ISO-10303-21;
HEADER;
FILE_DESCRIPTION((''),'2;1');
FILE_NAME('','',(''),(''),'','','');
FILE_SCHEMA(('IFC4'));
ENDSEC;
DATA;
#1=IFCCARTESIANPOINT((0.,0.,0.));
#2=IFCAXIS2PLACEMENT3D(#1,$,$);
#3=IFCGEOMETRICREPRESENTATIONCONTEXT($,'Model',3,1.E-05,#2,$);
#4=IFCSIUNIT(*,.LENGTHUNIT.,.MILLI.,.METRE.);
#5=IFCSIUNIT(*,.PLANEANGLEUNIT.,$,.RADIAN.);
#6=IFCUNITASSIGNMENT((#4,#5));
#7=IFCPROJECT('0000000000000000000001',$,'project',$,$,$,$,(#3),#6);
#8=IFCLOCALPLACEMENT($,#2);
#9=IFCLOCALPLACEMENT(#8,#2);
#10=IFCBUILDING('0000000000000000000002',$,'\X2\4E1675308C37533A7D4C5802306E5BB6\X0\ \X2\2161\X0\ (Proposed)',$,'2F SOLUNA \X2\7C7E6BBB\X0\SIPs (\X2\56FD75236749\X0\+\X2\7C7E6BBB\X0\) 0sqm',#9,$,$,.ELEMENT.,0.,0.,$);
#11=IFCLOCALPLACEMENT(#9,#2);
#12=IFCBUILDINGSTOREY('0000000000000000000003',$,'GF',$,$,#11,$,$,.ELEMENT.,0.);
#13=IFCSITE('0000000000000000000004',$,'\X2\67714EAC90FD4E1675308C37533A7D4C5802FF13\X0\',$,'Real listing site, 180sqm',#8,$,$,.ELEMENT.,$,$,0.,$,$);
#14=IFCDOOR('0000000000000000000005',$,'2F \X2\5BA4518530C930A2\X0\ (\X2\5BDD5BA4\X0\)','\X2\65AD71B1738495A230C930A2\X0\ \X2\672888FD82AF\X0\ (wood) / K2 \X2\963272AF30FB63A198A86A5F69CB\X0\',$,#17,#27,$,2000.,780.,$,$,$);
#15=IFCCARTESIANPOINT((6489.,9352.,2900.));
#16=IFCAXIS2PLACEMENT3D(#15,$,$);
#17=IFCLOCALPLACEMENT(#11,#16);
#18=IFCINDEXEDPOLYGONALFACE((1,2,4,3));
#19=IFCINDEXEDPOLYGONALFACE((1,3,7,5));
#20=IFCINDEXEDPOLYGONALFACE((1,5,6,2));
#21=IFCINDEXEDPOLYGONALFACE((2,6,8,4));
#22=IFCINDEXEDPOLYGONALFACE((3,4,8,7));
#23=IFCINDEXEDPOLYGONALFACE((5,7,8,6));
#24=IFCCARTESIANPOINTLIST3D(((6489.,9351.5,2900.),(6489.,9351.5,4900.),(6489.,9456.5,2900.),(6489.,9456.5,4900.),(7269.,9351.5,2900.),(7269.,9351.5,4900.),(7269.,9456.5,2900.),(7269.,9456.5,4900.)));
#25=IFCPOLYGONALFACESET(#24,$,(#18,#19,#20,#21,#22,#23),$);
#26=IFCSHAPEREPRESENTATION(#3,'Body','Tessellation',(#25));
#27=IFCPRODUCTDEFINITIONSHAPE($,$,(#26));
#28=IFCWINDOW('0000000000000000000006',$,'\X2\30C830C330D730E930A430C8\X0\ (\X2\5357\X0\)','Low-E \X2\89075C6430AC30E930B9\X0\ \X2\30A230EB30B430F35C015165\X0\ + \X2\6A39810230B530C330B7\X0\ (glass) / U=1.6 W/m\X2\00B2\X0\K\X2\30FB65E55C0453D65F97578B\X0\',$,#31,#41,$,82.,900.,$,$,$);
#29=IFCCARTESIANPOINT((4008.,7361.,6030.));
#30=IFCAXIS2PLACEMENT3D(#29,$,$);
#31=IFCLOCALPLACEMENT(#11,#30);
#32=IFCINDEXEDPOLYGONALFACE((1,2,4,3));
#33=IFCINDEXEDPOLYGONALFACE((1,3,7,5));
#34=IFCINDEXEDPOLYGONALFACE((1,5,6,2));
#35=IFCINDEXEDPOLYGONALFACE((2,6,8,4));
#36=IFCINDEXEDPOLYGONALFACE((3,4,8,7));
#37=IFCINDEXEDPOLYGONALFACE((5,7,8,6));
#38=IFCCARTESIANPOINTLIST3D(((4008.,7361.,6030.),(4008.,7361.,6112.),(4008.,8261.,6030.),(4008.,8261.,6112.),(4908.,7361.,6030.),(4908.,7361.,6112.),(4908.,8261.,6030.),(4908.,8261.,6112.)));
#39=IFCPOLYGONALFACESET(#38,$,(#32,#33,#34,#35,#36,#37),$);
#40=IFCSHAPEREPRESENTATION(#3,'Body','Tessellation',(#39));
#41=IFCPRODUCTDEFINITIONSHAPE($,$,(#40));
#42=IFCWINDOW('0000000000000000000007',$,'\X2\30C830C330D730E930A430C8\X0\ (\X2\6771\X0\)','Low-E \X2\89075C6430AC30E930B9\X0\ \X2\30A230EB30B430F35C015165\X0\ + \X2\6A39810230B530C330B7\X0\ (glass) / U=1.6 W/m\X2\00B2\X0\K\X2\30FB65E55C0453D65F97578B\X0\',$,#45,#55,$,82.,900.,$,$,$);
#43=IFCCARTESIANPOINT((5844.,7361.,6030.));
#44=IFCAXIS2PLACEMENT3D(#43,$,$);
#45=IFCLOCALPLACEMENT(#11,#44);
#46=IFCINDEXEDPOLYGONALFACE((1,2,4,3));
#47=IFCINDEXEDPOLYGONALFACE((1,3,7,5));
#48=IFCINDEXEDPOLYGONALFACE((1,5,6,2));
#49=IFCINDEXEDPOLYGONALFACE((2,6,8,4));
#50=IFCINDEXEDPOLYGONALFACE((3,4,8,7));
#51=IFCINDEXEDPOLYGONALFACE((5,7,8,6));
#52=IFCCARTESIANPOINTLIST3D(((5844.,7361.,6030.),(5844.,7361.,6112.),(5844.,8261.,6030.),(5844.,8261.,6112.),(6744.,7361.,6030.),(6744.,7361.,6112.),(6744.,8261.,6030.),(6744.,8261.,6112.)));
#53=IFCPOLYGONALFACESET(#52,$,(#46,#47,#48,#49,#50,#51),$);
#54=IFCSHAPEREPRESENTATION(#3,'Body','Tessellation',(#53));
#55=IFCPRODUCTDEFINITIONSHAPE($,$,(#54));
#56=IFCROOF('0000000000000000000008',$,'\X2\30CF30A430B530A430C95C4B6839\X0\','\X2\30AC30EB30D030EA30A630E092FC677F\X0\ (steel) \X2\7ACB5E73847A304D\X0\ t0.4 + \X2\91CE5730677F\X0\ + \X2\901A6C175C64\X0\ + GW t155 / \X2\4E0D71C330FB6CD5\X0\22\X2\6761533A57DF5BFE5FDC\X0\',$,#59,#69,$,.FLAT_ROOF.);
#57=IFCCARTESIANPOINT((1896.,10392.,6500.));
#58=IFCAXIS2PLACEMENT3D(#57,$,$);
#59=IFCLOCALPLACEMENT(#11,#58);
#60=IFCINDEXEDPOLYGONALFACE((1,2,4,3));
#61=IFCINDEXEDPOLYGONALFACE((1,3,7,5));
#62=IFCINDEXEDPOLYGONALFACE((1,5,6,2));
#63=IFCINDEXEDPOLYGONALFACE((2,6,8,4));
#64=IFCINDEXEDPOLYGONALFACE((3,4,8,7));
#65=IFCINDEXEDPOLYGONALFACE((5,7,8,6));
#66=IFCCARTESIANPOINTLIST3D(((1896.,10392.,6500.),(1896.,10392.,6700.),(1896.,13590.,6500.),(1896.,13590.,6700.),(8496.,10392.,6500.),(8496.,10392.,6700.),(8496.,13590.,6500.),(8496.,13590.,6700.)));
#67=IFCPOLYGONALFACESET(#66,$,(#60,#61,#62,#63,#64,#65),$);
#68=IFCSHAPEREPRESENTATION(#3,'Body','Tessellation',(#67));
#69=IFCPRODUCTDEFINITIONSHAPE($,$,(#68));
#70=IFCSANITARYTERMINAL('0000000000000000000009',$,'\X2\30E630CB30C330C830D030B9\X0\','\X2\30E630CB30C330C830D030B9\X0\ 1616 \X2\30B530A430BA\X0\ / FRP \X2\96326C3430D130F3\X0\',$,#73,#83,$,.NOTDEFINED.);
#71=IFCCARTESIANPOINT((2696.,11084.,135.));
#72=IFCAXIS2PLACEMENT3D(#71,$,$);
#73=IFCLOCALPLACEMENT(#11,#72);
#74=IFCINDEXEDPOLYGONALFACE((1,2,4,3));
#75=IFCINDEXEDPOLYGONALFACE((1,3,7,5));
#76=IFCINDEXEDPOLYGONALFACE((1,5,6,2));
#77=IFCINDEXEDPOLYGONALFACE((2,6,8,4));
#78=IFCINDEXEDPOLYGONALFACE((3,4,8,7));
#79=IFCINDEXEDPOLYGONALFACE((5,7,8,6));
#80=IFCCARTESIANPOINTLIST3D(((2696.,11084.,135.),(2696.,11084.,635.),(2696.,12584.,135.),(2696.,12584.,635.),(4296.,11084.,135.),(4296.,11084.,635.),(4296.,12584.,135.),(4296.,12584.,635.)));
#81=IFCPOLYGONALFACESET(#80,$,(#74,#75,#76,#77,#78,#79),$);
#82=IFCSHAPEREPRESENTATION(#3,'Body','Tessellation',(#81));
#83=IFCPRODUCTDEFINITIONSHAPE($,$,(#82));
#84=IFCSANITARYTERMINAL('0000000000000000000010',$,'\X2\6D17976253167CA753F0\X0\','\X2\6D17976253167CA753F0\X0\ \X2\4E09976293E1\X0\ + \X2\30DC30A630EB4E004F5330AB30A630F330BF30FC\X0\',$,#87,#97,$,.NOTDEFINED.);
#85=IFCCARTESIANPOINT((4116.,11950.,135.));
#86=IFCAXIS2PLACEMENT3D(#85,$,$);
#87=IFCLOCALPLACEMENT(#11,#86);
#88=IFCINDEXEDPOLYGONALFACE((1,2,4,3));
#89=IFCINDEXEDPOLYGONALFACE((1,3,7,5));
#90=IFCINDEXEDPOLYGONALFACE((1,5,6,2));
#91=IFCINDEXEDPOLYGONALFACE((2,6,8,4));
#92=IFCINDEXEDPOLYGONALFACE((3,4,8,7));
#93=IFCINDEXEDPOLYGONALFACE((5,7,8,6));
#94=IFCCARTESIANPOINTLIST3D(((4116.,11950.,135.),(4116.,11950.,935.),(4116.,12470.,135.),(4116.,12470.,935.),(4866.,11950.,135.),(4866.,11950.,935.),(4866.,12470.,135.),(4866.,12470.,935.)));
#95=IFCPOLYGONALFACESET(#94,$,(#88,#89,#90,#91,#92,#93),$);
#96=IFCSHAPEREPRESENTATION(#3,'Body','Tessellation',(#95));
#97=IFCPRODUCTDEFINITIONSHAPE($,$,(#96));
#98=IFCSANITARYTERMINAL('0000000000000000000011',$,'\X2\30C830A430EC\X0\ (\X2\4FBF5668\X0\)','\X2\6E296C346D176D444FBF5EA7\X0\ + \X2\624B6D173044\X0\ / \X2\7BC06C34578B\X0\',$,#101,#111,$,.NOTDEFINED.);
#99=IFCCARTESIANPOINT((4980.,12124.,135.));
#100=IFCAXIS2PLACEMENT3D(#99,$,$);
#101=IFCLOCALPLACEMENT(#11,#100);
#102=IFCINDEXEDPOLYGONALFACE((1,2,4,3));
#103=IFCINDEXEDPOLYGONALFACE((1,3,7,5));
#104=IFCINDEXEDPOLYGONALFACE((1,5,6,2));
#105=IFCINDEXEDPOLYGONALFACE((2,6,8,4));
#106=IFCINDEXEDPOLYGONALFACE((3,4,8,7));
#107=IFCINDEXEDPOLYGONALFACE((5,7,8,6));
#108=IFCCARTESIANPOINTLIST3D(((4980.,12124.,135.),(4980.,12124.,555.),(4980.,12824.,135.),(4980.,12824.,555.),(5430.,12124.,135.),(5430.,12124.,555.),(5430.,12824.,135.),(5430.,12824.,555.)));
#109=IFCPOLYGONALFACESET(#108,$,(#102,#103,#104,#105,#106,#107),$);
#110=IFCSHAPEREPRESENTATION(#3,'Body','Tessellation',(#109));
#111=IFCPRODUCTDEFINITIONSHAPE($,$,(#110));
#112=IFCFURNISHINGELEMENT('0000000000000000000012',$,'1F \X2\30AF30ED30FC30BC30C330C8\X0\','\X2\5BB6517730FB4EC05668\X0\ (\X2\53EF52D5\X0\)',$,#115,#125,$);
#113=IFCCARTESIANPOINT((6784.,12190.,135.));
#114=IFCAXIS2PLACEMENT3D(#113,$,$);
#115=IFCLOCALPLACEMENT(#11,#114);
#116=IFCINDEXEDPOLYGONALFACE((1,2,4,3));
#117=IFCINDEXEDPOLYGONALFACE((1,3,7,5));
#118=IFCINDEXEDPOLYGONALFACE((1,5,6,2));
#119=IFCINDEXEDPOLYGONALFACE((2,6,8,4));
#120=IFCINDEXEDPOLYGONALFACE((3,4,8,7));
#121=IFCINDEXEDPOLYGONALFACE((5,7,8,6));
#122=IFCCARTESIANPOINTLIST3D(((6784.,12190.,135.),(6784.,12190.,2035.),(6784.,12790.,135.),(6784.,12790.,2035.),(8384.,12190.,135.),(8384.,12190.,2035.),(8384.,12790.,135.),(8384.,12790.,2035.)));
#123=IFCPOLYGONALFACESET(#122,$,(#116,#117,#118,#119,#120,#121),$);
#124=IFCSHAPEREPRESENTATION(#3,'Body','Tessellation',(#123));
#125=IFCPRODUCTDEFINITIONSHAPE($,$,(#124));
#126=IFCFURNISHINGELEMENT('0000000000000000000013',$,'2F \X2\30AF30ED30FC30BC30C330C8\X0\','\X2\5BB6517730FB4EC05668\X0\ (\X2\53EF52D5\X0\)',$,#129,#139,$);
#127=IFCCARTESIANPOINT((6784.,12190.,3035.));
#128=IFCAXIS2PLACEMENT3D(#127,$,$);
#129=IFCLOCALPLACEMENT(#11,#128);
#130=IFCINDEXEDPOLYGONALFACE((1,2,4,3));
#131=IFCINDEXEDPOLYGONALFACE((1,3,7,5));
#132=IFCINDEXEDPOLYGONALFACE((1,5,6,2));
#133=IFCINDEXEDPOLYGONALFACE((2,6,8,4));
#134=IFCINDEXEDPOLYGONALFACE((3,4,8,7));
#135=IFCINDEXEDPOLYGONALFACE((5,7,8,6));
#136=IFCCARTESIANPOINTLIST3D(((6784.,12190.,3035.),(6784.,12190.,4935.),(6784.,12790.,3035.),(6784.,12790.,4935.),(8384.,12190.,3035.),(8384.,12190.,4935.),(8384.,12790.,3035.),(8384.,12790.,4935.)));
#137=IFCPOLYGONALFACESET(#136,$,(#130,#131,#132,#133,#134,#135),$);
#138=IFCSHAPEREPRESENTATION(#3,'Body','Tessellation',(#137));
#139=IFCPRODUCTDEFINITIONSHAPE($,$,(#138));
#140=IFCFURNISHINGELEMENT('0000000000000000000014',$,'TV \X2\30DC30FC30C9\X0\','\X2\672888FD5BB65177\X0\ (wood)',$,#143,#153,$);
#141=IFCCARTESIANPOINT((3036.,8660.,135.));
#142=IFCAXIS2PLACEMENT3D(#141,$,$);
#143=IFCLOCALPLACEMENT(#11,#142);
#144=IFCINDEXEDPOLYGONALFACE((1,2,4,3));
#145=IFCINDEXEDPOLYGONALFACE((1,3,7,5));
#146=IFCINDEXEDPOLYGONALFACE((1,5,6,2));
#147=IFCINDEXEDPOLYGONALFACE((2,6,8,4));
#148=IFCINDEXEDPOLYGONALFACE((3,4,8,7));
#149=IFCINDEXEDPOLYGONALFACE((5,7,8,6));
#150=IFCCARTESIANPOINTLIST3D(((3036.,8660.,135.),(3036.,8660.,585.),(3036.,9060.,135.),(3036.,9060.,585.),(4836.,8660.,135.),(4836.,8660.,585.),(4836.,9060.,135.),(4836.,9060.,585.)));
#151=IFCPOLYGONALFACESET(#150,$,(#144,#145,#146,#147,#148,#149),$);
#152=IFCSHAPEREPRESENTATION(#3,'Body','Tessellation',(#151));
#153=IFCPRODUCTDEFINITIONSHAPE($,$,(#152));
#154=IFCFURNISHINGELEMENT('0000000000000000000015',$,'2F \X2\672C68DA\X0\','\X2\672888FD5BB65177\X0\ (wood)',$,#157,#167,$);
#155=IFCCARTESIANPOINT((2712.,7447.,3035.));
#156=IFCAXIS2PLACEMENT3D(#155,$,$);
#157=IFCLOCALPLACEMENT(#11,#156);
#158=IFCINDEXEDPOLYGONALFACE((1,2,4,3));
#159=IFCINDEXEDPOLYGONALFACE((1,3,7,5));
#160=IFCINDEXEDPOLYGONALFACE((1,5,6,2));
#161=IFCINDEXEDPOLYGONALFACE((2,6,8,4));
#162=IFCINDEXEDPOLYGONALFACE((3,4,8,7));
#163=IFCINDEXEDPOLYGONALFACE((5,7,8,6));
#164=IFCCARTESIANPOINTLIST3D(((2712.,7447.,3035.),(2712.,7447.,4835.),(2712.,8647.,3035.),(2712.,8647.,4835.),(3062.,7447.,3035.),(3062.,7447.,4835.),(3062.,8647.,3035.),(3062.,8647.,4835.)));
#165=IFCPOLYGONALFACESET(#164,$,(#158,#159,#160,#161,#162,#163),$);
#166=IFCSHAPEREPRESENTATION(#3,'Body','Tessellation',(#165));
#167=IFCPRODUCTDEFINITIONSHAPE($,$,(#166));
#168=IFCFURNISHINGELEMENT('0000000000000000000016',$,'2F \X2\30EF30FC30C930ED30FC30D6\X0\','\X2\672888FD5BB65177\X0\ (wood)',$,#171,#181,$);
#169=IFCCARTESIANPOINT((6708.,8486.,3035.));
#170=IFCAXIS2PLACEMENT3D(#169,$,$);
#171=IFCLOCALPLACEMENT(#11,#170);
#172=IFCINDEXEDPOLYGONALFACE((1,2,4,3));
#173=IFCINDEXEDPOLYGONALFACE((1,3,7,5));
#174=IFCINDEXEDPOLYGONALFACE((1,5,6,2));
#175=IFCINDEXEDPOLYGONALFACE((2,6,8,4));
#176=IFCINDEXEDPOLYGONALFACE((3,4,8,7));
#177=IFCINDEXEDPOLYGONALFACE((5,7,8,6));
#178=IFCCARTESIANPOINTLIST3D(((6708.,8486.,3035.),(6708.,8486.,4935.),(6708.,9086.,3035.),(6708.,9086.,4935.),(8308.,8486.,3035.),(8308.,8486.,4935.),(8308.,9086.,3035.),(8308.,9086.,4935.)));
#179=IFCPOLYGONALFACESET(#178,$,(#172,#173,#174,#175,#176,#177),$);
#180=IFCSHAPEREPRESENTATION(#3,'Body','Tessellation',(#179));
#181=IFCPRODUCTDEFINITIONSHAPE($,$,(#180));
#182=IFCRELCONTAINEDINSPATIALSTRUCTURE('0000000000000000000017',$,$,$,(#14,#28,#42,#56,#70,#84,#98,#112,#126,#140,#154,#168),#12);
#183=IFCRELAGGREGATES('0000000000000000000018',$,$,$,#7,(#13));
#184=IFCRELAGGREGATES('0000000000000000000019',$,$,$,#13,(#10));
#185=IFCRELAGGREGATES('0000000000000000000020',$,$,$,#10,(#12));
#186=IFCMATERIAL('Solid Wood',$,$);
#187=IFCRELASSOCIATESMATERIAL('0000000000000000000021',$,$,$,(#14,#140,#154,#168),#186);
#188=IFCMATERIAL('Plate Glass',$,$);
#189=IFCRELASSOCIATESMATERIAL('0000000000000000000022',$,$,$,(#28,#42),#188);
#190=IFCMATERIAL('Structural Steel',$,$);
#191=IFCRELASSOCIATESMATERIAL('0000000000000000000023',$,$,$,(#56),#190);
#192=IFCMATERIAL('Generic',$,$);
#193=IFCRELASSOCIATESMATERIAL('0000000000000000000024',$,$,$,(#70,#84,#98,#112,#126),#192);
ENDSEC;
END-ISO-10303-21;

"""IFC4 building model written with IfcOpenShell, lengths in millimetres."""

from ifc_helpers import new_model, si_unit, frame, frame_2d, origin, place, context, project, spatial, rectangle, extrude, material, element, save


model = new_model("IFC4")

# Units and contexts
model_context = context("Model", 3, precision=1e-05, world=origin())
ifc_project = project(units=[si_unit("LENGTHUNIT", "METRE", prefix="MILLI"), si_unit("PLANEANGLEUNIT", "RADIAN")], contexts=[model_context])

# Site, building, storey
site_placement = place(None, origin())
site = spatial("IfcSite", under=ifc_project, at=site_placement, Name="東京都世田谷区経堂３", ObjectType="Real listing site, 180sqm", CompositionType="ELEMENT", RefElevation=0.0)
building_placement = place(site_placement, origin())
building = spatial("IfcBuilding", under=site, at=building_placement, Name="世田谷区経堂の家 Ⅱ (Proposed)", ObjectType="2F SOLUNA 籾殻SIPs (国産杉+籾殻) 0sqm", CompositionType="ELEMENT", ElevationOfRefHeight=0.0, ElevationOfTerrain=0.0)
storey_placement = place(building_placement, origin())
storey = spatial("IfcBuildingStorey", under=building, at=storey_placement, Name="GF", CompositionType="ELEMENT", Elevation=0.0)

# Shared definitions
ifc_material_1 = material(Name="Solid Wood")
ifc_material_2 = material(Name="Plate Glass")

# Door
door_1_placement = place(storey_placement, frame((6489.0, 9352.0, 2900.0)))
element("IfcDoor", 1, at=door_1_placement, inside=storey, material=ifc_material_1, Name="2F 室内ドア (寝室)", Description="断熱玄関ドア 木製芯 (wood) / K2 防犯・採風機構", OverallHeight=2000.0, OverallWidth=780.0, context=model_context, shape_type="SweptSolid", body=[
    extrude(rectangle(XDim=780.0, YDim=105.0, at=frame_2d((390.0, 52.0))), frame((6489.0, 9352.0, 2900.0)), (0.0, 0.0, 1.0), 2000.0),
])

# Windows
window_1_placement = place(storey_placement, frame((4008.0, 7361.0, 6030.0)))
element("IfcWindow", 2, at=window_1_placement, inside=storey, material=ifc_material_2, Name="トップライト (南)", Description="Low-E 複層ガラス アルゴン封入 + 樹脂サッシ (glass) / U=1.6 W/m²K・日射取得型", OverallHeight=82.0, OverallWidth=900.0, context=model_context, shape_type="SweptSolid", body=[
    extrude(rectangle(XDim=900.0, YDim=900.0, at=frame_2d((450.0, 450.0))), frame((4008.0, 7361.0, 6030.0)), (0.0, 0.0, 1.0), 82.0),
])
window_2_placement = place(storey_placement, frame((5844.0, 7361.0, 6030.0)))
element("IfcWindow", 3, at=window_2_placement, inside=storey, material=ifc_material_2, Name="トップライト (東)", Description="Low-E 複層ガラス アルゴン封入 + 樹脂サッシ (glass) / U=1.6 W/m²K・日射取得型", OverallHeight=82.0, OverallWidth=900.0, context=model_context, shape_type="SweptSolid", body=[
    extrude(rectangle(XDim=900.0, YDim=900.0, at=frame_2d((450.0, 450.0))), frame((5844.0, 7361.0, 6030.0)), (0.0, 0.0, 1.0), 82.0),
])

# Roof
ifc_material_3 = material(Name="Structural Steel")
roof_placement = place(storey_placement, frame((1896.0, 10392.0, 6500.0)))
element("IfcRoof", 4, at=roof_placement, inside=storey, material=ifc_material_3, Name="ハイサイド屋根", Description="ガルバリウム鋼板 (steel) 立平葺き t0.4 + 野地板 + 通気層 + GW t155 / 不燃・法22条区域対応", PredefinedType="FLAT_ROOF", context=model_context, shape_type="SweptSolid", body=[
    extrude(rectangle(XDim=6600.0, YDim=3198.0, at=frame_2d((3300.0, 1599.0))), frame((1896.0, 10392.0, 6500.0)), (0.0, 0.0, 1.0), 200.0),
])

# Sanitary terminals
ifc_material_4 = material(Name="Generic")
sanitary_terminal_1_placement = place(storey_placement, frame((2696.0, 11084.0, 135.0)))
element("IfcSanitaryTerminal", 5, at=sanitary_terminal_1_placement, inside=storey, material=ifc_material_4, Name="ユニットバス", Description="ユニットバス 1616 サイズ / FRP 防水パン", PredefinedType="NOTDEFINED", context=model_context, shape_type="SweptSolid", body=[
    extrude(rectangle(XDim=1600.0, YDim=1500.0, at=frame_2d((800.0, 750.0))), frame((2696.0, 11084.0, 135.0)), (0.0, 0.0, 1.0), 500.0),
])
sanitary_terminal_2_placement = place(storey_placement, frame((4116.0, 11950.0, 135.0)))
element("IfcSanitaryTerminal", 6, at=sanitary_terminal_2_placement, inside=storey, material=ifc_material_4, Name="洗面化粧台", Description="洗面化粧台 三面鏡 + ボウル一体カウンター", PredefinedType="NOTDEFINED", context=model_context, shape_type="SweptSolid", body=[
    extrude(rectangle(XDim=750.0, YDim=520.0, at=frame_2d((375.0, 260.0))), frame((4116.0, 11950.0, 135.0)), (0.0, 0.0, 1.0), 800.0),
])
sanitary_terminal_3_placement = place(storey_placement, frame((4980.0, 12124.0, 135.0)))
element("IfcSanitaryTerminal", 7, at=sanitary_terminal_3_placement, inside=storey, material=ifc_material_4, Name="トイレ (便器)", Description="温水洗浄便座 + 手洗い / 節水型", PredefinedType="NOTDEFINED", context=model_context, shape_type="SweptSolid", body=[
    extrude(rectangle(XDim=450.0, YDim=700.0, at=frame_2d((225.0, 350.0))), frame((4980.0, 12124.0, 135.0)), (0.0, 0.0, 1.0), 420.0),
])

# Furnishing elements
furnishing_1_placement = place(storey_placement, frame((6784.0, 12190.0, 135.0)))
element("IfcFurnishingElement", 8, at=furnishing_1_placement, inside=storey, material=ifc_material_4, Name="1F クローゼット", Description="家具・什器 (可動)", context=model_context, shape_type="SweptSolid", body=[
    extrude(rectangle(XDim=1600.0, YDim=600.0, at=frame_2d((800.0, 300.0))), frame((6784.0, 12190.0, 135.0)), (0.0, 0.0, 1.0), 1900.0),
])
furnishing_2_placement = place(storey_placement, frame((6784.0, 12190.0, 3035.0)))
element("IfcFurnishingElement", 9, at=furnishing_2_placement, inside=storey, material=ifc_material_4, Name="2F クローゼット", Description="家具・什器 (可動)", context=model_context, shape_type="SweptSolid", body=[
    extrude(rectangle(XDim=1600.0, YDim=600.0, at=frame_2d((800.0, 300.0))), frame((6784.0, 12190.0, 3035.0)), (0.0, 0.0, 1.0), 1900.0),
])
furnishing_3_placement = place(storey_placement, frame((3036.0, 8660.0, 135.0)))
element("IfcFurnishingElement", 10, at=furnishing_3_placement, inside=storey, material=ifc_material_1, Name="TV ボード", Description="木製家具 (wood)", context=model_context, shape_type="SweptSolid", body=[
    extrude(rectangle(XDim=1800.0, YDim=400.0, at=frame_2d((900.0, 200.0))), frame((3036.0, 8660.0, 135.0)), (0.0, 0.0, 1.0), 450.0),
])
furnishing_4_placement = place(storey_placement, frame((2712.0, 7447.0, 3035.0)))
element("IfcFurnishingElement", 11, at=furnishing_4_placement, inside=storey, material=ifc_material_1, Name="2F 本棚", Description="木製家具 (wood)", context=model_context, shape_type="SweptSolid", body=[
    extrude(rectangle(XDim=350.0, YDim=1200.0, at=frame_2d((175.0, 600.0))), frame((2712.0, 7447.0, 3035.0)), (0.0, 0.0, 1.0), 1800.0),
])
furnishing_5_placement = place(storey_placement, frame((6708.0, 8486.0, 3035.0)))
element("IfcFurnishingElement", 12, at=furnishing_5_placement, inside=storey, material=ifc_material_1, Name="2F ワードローブ", Description="木製家具 (wood)", context=model_context, shape_type="SweptSolid", body=[
    extrude(rectangle(XDim=1600.0, YDim=600.0, at=frame_2d((800.0, 300.0))), frame((6708.0, 8486.0, 3035.0)), (0.0, 0.0, 1.0), 1900.0),
])

save(model, "model.ifc")
